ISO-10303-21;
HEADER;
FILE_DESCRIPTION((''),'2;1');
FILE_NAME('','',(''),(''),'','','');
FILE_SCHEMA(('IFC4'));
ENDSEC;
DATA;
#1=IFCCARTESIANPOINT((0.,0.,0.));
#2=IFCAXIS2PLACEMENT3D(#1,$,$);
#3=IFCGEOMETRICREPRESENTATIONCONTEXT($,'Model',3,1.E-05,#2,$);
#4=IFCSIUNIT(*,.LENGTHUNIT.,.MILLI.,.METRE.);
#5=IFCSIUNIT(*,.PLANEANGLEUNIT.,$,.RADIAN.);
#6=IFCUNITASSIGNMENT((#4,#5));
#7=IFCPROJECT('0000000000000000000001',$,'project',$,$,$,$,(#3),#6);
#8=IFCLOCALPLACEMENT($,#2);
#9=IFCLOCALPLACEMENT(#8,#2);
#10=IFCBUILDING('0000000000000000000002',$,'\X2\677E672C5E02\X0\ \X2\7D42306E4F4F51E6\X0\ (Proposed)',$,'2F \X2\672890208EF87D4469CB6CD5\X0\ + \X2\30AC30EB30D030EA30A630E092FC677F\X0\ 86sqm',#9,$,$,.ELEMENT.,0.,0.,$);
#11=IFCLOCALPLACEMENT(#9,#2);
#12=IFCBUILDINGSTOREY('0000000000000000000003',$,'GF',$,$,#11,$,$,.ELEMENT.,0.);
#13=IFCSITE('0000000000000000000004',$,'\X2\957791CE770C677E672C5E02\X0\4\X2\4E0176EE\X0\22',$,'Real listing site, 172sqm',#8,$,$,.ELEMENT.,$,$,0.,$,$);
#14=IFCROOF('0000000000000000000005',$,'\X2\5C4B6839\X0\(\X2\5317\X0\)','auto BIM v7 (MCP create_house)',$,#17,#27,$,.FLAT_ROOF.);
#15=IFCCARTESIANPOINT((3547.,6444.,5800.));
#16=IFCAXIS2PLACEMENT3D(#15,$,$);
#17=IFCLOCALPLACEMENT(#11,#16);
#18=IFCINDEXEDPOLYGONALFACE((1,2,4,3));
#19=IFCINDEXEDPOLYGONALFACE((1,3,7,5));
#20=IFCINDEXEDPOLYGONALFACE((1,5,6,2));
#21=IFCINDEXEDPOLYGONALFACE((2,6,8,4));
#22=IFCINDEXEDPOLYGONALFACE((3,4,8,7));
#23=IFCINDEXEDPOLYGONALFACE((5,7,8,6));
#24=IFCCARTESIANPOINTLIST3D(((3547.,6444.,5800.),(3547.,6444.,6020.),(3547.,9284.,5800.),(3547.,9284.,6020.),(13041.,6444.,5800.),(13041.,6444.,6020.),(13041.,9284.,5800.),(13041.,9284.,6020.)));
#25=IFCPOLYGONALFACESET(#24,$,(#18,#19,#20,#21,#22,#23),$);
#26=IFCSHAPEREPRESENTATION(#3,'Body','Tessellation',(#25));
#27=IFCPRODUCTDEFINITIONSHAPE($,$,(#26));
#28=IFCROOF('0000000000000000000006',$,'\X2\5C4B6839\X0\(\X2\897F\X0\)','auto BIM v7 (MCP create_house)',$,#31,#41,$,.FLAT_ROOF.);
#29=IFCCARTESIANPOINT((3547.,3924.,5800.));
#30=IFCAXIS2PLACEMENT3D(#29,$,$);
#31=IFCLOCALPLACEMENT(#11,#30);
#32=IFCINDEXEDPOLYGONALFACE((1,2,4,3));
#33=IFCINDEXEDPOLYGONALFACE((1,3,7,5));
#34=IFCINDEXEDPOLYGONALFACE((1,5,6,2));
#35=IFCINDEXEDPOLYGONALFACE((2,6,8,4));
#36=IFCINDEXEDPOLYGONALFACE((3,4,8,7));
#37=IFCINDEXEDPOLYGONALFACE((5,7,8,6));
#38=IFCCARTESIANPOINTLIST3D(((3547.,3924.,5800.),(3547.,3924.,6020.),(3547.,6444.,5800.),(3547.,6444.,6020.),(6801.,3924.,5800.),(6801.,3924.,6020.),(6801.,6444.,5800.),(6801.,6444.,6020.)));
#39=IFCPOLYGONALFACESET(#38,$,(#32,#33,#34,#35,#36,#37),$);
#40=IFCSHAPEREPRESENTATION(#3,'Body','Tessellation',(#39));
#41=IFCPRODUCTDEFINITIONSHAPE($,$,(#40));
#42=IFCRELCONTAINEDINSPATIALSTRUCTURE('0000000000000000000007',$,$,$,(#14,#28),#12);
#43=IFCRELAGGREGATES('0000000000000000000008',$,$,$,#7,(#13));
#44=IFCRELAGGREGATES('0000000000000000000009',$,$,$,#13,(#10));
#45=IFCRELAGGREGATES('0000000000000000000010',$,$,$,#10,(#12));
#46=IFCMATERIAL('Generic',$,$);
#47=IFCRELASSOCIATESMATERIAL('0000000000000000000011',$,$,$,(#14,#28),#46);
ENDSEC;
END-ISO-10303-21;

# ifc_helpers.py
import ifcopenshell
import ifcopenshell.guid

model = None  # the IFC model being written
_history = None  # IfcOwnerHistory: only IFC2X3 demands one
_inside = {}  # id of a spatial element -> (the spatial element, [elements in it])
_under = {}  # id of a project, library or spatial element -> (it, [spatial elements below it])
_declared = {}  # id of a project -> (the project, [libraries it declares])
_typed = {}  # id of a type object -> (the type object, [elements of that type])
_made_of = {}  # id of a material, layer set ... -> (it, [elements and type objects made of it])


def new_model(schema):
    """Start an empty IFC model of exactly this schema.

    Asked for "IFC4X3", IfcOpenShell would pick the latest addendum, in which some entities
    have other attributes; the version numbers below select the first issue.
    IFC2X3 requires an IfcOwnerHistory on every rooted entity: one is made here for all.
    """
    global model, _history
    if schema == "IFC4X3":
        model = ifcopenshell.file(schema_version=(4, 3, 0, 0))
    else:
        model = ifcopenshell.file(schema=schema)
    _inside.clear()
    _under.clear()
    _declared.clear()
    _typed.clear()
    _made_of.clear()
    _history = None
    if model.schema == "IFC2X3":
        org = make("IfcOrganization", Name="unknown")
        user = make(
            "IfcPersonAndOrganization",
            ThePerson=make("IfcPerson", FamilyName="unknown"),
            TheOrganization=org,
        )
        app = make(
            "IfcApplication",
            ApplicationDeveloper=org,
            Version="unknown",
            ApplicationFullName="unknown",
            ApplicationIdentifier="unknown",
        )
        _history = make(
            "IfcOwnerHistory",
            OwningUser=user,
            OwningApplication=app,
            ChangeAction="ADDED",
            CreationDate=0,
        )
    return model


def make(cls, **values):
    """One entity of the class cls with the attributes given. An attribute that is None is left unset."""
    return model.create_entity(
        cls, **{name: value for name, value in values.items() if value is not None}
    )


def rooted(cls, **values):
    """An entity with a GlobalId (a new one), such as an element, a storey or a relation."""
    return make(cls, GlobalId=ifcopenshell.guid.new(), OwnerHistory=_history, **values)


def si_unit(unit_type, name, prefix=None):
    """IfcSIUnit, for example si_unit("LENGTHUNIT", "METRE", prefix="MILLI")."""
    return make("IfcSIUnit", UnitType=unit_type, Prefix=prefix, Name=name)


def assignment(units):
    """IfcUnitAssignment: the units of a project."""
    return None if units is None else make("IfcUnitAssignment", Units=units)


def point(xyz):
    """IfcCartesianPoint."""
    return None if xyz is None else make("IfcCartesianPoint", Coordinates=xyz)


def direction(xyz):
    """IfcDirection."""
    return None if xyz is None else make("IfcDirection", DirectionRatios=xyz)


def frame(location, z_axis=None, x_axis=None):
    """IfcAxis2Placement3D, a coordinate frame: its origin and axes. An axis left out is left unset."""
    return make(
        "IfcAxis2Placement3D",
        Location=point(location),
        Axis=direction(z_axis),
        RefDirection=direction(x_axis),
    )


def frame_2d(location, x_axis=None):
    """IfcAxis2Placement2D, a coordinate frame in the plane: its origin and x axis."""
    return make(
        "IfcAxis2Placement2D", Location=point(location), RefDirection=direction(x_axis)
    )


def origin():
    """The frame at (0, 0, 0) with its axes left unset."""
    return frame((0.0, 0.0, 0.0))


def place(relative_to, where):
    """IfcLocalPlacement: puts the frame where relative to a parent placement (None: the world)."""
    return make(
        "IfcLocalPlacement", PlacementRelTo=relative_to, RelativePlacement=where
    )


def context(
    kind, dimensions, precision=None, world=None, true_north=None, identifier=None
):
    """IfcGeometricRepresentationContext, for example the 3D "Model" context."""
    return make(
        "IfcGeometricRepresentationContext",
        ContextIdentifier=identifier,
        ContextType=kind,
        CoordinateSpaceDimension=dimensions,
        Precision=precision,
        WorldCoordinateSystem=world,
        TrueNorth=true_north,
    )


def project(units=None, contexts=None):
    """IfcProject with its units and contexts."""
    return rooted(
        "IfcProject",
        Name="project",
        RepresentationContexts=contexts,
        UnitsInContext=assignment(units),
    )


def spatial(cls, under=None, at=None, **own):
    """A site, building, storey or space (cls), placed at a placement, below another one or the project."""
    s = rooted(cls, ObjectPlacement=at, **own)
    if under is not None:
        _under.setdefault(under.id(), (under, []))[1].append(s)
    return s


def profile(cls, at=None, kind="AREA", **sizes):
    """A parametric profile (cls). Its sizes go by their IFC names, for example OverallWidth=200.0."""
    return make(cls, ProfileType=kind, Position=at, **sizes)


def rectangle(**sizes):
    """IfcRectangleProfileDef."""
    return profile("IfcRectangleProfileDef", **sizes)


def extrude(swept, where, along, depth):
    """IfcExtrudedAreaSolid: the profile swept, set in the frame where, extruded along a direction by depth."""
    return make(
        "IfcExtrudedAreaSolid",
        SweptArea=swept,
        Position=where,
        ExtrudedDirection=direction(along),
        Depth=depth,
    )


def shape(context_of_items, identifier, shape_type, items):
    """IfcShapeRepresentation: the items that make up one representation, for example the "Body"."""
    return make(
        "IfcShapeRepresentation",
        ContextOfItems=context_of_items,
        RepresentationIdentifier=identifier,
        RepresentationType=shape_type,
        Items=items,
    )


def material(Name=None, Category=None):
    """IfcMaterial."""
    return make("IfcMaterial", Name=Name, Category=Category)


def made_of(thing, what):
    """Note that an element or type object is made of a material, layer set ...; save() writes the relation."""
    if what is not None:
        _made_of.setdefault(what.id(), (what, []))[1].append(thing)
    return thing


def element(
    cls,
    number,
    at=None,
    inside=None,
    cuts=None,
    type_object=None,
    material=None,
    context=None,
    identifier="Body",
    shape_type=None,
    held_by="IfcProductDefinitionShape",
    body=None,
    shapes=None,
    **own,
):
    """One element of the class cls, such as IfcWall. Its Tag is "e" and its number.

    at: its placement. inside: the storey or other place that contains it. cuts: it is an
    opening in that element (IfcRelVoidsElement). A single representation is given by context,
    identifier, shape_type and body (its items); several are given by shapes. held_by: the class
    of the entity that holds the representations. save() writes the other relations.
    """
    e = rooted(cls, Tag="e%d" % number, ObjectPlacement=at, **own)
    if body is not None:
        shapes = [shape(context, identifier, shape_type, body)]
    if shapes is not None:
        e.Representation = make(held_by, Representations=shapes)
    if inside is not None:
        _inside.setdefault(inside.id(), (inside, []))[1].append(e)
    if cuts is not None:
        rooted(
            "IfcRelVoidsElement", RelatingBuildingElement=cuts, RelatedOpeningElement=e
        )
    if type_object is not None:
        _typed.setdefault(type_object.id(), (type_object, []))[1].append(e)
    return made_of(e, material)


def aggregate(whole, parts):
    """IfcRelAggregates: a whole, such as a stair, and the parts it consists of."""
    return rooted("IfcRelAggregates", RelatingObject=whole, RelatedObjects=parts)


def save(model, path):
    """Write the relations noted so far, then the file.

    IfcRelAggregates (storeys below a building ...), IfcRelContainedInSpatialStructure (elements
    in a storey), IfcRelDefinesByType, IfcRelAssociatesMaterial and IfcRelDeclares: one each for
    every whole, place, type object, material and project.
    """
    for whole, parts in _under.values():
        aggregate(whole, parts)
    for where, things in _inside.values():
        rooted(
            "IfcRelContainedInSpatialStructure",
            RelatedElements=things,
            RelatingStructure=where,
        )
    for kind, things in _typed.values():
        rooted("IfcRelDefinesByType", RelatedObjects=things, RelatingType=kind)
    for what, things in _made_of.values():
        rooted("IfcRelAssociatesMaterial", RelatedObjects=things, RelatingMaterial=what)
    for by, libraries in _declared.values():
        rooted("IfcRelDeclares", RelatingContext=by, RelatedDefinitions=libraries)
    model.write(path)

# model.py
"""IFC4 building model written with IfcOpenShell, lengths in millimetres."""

from ifc_helpers import new_model, si_unit, frame, frame_2d, origin, place, context, project, spatial, rectangle, extrude, material, element, save


model = new_model("IFC4")

# Units and contexts
model_context = context("Model", 3, precision=1e-05, world=origin())
ifc_project = project(units=[si_unit("LENGTHUNIT", "METRE", prefix="MILLI"), si_unit("PLANEANGLEUNIT", "RADIAN")], contexts=[model_context])

# Site, building, storey
site_placement = place(None, origin())
site = spatial("IfcSite", under=ifc_project, at=site_placement, Name="長野県松本市4丁目22", ObjectType="Real listing site, 172sqm", CompositionType="ELEMENT", RefElevation=0.0)
building_placement = place(site_placement, origin())
building = spatial("IfcBuilding", under=site, at=building_placement, Name="松本市 終の住処 (Proposed)", ObjectType="2F 木造軸組構法 + ガルバリウム鋼板 86sqm", CompositionType="ELEMENT", ElevationOfRefHeight=0.0, ElevationOfTerrain=0.0)
storey_placement = place(building_placement, origin())
storey = spatial("IfcBuildingStorey", under=building, at=storey_placement, Name="GF", CompositionType="ELEMENT", Elevation=0.0)

# Shared definitions
ifc_material = material(Name="Generic")

# Roofs
roof_1_placement = place(storey_placement, frame((3547.0, 6444.0, 5800.0)))
element("IfcRoof", 1, at=roof_1_placement, inside=storey, material=ifc_material, Name="屋根(北)", Description="auto BIM v7 (MCP create_house)", PredefinedType="FLAT_ROOF", context=model_context, shape_type="SweptSolid", body=[
    extrude(rectangle(XDim=9494.0, YDim=2840.0, at=frame_2d((4747.0, 1420.0))), frame((3547.0, 6444.0, 5800.0)), (0.0, 0.0, 1.0), 220.0),
])
roof_2_placement = place(storey_placement, frame((3547.0, 3924.0, 5800.0)))
element("IfcRoof", 2, at=roof_2_placement, inside=storey, material=ifc_material, Name="屋根(西)", Description="auto BIM v7 (MCP create_house)", PredefinedType="FLAT_ROOF", context=model_context, shape_type="SweptSolid", body=[
    extrude(rectangle(XDim=3254.0, YDim=2520.0, at=frame_2d((1627.0, 1260.0))), frame((3547.0, 3924.0, 5800.0)), (0.0, 0.0, 1.0), 220.0),
])

save(model, "model.ifc")
